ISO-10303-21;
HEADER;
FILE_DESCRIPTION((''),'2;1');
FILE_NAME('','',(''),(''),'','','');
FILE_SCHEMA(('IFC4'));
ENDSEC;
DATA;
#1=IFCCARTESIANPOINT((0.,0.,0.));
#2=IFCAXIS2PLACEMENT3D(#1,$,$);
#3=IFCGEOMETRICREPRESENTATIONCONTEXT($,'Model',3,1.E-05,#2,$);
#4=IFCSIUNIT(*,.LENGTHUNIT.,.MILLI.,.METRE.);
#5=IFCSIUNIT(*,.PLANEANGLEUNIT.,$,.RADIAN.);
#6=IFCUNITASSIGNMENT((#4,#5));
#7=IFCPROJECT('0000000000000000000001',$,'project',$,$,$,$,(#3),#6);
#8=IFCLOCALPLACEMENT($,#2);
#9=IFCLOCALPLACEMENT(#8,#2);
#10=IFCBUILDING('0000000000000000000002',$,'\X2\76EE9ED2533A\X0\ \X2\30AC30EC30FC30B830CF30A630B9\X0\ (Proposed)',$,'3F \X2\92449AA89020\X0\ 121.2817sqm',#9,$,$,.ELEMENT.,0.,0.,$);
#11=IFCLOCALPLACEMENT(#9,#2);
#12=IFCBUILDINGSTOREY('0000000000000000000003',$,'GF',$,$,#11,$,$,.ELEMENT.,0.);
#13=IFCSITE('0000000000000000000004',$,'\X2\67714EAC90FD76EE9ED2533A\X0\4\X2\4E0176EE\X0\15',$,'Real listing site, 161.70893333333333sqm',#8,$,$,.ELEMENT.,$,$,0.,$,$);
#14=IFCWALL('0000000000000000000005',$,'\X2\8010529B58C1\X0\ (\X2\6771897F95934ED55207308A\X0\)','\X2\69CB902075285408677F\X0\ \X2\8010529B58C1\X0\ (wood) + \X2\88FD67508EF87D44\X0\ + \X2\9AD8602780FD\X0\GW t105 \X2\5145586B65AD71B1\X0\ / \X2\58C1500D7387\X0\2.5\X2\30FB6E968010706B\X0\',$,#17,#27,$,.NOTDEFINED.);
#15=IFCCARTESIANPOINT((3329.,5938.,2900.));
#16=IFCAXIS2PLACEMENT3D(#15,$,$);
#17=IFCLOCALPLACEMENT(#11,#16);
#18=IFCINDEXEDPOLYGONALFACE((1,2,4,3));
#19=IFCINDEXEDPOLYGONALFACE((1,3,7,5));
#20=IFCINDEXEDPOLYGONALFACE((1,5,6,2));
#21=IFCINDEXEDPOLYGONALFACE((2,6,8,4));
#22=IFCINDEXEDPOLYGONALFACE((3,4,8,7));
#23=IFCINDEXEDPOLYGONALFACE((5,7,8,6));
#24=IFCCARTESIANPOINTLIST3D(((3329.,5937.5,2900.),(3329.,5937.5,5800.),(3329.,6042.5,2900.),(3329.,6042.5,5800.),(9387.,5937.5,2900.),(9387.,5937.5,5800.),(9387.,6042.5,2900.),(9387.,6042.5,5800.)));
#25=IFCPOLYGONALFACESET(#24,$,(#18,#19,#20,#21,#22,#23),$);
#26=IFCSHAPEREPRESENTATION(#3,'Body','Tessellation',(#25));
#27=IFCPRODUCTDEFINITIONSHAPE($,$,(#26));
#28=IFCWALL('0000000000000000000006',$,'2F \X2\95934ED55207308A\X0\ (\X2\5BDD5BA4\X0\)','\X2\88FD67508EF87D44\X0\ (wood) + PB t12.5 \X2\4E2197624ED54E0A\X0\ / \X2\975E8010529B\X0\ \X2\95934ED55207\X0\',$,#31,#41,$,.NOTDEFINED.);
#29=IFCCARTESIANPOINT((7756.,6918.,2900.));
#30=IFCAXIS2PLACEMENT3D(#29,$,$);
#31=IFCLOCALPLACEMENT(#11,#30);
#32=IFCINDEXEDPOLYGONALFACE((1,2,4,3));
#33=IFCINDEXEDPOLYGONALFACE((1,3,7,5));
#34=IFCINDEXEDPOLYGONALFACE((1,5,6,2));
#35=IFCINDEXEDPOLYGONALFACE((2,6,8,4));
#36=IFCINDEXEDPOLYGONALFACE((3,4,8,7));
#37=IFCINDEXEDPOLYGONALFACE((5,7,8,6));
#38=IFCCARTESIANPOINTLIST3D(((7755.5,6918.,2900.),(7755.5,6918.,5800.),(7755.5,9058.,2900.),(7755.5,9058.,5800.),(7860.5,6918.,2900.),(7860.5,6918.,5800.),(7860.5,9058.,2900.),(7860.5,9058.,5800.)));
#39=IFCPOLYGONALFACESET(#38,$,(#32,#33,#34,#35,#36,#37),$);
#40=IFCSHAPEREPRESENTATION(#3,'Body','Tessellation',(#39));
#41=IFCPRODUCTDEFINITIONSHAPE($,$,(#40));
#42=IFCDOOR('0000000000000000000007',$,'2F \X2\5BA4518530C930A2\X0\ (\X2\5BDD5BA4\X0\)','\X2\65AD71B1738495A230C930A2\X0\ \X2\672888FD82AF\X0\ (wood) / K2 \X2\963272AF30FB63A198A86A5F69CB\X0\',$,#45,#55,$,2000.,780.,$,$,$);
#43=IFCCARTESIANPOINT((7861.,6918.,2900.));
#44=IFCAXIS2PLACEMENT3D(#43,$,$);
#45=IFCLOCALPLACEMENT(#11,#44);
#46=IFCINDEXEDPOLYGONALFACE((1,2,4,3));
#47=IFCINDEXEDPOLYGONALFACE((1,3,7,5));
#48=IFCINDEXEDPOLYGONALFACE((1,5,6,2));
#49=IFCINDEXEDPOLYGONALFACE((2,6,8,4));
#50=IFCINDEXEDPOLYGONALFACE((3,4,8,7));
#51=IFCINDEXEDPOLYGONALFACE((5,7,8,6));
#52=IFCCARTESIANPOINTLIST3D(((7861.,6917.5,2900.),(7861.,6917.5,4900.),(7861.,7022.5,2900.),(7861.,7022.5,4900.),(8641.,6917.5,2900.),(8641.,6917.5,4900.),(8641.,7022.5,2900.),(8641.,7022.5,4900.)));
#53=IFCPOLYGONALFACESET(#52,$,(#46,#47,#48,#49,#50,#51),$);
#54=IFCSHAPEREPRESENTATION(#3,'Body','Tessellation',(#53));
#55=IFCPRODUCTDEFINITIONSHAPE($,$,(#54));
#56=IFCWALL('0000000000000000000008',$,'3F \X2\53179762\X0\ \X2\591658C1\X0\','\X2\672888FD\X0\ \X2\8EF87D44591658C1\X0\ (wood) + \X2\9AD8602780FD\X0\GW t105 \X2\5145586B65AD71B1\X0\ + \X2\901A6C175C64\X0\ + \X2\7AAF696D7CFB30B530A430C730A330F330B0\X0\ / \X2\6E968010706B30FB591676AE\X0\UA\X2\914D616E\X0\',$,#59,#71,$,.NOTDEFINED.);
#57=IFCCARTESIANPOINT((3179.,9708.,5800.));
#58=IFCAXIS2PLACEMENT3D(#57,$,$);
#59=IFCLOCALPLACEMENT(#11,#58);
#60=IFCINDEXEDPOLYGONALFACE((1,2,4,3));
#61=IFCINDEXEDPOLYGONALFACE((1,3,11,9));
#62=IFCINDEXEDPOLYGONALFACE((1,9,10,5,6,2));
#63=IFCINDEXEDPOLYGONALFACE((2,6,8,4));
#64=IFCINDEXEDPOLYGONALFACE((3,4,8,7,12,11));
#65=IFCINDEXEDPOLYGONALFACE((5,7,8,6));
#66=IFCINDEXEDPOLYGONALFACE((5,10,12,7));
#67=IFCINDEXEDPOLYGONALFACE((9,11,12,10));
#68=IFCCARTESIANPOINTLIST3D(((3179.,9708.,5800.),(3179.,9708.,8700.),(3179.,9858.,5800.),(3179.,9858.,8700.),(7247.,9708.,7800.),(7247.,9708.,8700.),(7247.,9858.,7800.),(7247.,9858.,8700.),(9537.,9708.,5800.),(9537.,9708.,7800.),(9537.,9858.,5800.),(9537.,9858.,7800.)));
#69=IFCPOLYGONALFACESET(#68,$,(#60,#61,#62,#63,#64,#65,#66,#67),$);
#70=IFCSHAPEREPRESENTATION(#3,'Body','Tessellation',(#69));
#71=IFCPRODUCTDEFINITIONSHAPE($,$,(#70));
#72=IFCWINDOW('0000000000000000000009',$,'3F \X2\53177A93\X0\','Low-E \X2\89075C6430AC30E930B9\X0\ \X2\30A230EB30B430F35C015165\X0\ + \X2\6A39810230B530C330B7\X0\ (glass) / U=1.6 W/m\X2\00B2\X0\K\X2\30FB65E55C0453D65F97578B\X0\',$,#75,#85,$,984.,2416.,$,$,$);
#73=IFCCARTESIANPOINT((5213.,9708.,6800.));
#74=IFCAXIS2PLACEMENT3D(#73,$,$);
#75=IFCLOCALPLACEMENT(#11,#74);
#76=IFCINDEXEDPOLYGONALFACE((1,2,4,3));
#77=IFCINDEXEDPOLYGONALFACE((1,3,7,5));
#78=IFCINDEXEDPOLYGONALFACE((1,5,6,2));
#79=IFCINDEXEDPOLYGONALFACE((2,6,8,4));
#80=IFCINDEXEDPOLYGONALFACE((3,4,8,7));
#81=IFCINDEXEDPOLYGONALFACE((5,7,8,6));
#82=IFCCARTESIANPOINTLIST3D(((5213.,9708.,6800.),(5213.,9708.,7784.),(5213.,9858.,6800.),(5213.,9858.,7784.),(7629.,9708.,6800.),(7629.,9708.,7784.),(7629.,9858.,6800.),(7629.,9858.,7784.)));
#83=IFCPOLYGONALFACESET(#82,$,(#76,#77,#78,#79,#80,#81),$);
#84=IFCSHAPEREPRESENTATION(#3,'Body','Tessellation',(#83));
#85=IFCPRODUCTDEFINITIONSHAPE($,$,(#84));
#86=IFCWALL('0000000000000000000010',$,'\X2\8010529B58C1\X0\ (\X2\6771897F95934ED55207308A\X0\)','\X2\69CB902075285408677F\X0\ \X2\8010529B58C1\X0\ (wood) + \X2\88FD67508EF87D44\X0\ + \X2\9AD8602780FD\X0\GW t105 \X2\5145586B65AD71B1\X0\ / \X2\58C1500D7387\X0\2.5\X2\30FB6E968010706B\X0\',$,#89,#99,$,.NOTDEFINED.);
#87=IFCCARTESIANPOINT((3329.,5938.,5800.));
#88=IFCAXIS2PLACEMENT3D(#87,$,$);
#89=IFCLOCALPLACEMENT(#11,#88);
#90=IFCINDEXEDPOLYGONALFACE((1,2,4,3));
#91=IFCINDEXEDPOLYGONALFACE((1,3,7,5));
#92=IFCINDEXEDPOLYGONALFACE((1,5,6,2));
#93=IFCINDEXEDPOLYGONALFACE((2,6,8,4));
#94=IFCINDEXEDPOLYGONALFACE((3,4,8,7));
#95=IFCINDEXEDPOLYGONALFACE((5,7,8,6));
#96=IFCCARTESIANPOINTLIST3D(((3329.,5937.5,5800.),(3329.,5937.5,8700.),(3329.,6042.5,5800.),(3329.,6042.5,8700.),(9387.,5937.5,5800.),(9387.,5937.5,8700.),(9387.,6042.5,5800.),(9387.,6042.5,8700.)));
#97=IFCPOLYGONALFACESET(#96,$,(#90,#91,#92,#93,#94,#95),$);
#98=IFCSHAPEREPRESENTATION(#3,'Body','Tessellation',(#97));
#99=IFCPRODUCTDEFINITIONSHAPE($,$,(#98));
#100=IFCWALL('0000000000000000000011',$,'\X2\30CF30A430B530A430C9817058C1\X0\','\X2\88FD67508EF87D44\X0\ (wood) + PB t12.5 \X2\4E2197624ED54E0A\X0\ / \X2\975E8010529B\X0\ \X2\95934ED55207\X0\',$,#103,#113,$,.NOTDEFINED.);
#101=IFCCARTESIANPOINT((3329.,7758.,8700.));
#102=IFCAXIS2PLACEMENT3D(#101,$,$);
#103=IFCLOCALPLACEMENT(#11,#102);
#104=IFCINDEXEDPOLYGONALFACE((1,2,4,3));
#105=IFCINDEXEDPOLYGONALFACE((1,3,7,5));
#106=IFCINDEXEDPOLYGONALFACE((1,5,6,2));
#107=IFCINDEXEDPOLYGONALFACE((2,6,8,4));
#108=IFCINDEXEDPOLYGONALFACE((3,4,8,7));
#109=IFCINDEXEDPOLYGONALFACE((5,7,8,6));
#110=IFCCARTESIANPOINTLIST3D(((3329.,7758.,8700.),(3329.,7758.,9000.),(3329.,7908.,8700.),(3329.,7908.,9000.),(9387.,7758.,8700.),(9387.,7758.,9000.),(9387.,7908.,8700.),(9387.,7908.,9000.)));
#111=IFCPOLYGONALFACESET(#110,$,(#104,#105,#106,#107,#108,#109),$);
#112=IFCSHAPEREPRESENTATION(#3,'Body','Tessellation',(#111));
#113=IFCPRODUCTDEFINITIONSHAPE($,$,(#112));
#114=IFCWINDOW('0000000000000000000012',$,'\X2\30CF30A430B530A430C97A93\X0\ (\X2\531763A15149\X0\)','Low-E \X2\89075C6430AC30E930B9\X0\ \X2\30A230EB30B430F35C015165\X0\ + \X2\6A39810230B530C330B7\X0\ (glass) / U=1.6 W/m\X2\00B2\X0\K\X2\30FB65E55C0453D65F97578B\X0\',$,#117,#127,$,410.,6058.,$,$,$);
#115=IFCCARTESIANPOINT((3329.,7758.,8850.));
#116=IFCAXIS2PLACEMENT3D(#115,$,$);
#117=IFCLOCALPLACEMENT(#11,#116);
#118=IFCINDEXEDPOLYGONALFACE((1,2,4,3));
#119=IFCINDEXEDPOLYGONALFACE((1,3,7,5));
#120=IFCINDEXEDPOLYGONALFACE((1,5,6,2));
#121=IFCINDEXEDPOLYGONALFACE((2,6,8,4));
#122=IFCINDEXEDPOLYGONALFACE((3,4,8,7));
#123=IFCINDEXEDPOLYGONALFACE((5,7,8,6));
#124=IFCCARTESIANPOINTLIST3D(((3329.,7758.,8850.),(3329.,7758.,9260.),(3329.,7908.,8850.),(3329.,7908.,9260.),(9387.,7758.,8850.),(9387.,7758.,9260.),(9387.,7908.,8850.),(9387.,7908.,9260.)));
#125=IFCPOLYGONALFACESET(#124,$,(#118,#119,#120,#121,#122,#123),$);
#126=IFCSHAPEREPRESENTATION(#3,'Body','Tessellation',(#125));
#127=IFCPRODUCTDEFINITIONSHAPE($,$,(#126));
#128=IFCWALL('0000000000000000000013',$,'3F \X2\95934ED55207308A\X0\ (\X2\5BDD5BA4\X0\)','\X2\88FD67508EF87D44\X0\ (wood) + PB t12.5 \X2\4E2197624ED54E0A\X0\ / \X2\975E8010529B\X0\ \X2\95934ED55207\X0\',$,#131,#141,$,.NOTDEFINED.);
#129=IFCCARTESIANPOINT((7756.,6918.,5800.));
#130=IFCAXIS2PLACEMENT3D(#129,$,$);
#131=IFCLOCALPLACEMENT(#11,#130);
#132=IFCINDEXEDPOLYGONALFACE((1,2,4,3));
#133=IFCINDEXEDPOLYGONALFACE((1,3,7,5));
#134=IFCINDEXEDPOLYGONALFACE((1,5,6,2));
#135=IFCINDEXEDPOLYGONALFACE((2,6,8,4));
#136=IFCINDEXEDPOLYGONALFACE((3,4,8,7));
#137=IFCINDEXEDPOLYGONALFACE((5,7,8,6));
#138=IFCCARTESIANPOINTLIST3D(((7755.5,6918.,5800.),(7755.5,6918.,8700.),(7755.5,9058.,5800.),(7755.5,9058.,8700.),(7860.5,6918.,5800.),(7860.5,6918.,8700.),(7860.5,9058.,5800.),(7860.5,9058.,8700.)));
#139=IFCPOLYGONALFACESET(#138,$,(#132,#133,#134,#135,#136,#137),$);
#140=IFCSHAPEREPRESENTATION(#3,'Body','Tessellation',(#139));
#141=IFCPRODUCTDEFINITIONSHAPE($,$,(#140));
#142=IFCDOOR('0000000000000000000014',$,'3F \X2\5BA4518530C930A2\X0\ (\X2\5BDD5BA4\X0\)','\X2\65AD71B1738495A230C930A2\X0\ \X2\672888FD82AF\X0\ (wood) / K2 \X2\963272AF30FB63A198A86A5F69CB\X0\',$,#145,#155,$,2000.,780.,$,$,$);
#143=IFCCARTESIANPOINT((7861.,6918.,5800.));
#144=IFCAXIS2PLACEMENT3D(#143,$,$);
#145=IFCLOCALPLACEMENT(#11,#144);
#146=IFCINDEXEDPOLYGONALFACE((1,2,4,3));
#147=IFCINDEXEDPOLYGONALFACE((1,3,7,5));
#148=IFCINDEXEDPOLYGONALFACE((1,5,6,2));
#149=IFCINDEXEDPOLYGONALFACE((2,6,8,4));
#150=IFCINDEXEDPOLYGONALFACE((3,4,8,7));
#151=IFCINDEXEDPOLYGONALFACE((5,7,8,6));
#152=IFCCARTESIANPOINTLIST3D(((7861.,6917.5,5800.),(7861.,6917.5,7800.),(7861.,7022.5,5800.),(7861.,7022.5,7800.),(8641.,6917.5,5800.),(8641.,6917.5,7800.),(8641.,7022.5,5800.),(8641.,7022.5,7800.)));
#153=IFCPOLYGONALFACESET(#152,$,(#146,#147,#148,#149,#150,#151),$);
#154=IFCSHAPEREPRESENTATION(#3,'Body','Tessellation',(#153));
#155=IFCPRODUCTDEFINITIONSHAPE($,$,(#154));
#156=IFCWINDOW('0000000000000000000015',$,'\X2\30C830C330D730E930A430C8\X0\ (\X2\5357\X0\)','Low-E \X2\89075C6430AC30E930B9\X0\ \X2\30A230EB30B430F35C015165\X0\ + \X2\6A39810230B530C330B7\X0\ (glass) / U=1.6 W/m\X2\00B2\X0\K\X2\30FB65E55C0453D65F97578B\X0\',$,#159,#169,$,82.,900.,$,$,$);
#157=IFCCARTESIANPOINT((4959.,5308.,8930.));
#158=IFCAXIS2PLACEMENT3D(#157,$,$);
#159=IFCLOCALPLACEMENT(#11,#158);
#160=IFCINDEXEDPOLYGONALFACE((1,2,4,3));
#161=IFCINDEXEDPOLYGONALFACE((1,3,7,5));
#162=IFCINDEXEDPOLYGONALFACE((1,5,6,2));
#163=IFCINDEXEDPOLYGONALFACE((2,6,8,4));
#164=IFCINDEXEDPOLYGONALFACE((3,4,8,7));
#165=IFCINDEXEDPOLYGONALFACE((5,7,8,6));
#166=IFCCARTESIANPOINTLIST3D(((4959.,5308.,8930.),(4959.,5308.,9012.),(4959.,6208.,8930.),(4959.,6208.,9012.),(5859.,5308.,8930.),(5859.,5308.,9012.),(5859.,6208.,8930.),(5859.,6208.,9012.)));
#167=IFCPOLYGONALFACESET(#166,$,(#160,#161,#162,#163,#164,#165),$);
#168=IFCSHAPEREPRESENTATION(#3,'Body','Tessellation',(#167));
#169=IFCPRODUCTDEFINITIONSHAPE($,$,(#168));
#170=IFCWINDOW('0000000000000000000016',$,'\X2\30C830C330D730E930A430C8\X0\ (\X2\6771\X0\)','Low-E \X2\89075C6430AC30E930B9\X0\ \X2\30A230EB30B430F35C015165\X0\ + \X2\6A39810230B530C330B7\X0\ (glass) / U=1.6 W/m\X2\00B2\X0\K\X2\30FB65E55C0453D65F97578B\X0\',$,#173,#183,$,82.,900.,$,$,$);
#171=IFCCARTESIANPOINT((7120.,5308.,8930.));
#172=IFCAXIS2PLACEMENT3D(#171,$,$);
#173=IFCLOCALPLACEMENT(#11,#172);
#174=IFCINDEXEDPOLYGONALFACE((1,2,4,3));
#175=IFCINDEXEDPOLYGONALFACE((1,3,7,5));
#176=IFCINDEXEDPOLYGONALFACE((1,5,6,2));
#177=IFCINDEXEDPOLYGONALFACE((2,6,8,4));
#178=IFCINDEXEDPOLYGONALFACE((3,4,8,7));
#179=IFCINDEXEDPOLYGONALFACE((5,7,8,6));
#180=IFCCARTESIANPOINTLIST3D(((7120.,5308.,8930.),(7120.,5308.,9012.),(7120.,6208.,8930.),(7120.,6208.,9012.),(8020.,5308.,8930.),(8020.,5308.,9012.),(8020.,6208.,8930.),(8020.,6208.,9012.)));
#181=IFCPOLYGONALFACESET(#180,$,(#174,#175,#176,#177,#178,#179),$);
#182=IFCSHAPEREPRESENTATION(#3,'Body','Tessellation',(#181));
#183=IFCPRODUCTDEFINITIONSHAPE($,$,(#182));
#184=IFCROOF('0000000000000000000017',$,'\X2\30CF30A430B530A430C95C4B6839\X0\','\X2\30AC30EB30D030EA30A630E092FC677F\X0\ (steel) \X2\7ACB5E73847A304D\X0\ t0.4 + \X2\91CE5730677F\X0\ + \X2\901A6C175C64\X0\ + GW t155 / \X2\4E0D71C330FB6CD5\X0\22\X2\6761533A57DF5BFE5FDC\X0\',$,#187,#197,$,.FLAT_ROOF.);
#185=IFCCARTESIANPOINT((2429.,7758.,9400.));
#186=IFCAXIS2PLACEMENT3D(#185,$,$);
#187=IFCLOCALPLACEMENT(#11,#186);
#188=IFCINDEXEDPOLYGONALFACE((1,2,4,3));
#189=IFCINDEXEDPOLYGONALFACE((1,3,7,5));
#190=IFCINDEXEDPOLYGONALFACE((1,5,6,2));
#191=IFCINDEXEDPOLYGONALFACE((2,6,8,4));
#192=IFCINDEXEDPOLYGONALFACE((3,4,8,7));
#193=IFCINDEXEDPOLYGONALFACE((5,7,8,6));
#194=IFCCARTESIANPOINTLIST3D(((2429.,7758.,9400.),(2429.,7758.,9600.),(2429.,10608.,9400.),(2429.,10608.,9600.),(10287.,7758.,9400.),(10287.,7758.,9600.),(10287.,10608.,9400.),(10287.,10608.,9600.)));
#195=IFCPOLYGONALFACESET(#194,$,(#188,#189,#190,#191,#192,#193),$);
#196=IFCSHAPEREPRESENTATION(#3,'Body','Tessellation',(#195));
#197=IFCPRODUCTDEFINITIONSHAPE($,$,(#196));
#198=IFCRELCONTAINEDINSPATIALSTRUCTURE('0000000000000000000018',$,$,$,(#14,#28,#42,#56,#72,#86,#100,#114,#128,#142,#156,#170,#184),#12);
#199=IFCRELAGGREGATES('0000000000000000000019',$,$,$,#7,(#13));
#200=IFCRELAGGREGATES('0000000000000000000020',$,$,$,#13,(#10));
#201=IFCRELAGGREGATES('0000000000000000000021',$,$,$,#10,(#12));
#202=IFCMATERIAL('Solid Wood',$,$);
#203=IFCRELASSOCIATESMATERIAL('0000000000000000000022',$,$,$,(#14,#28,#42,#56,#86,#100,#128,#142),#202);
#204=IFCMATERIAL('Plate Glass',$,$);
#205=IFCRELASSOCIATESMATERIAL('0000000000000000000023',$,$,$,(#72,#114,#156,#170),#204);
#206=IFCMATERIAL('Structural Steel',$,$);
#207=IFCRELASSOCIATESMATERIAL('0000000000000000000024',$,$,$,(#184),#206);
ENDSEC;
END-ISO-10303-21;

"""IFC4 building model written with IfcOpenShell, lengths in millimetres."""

from ifc_helpers import new_model, si_unit, frame, frame_2d, origin, place, context, project, spatial, rectangle, extrude, material, element, fill, save


model = new_model("IFC4")

# Units and contexts
model_context = context("Model", 3, precision=1e-05, world=origin())
ifc_project = project(units=[si_unit("LENGTHUNIT", "METRE", prefix="MILLI"), si_unit("PLANEANGLEUNIT", "RADIAN")], contexts=[model_context])

# Site, building, storey
site_placement = place(None, origin())
site = spatial("IfcSite", under=ifc_project, at=site_placement, Name="東京都目黒区4丁目15", ObjectType="Real listing site, 161.70893333333333sqm", CompositionType="ELEMENT", RefElevation=0.0)
building_placement = place(site_placement, origin())
building = spatial("IfcBuilding", under=site, at=building_placement, Name="目黒区 ガレージハウス (Proposed)", ObjectType="3F 鉄骨造 121.2817sqm", CompositionType="ELEMENT", ElevationOfRefHeight=0.0, ElevationOfTerrain=0.0)
storey_placement = place(building_placement, origin())
storey = spatial("IfcBuildingStorey", under=building, at=storey_placement, Name="GF", CompositionType="ELEMENT", Elevation=0.0)

# Walls
ifc_material_1 = material(Name="Solid Wood")
wall_1_placement = place(storey_placement, frame((3329.0, 5938.0, 2900.0)))
element("IfcWall", 1, at=wall_1_placement, inside=storey, material=ifc_material_1, Name="耐力壁 (東西間仕切り)", Description="構造用合板 耐力壁 (wood) + 製材軸組 + 高性能GW t105 充填断熱 / 壁倍率2.5・準耐火", PredefinedType="NOTDEFINED", context=model_context, shape_type="SweptSolid", body=[
    extrude(rectangle(XDim=6058.0, YDim=105.0, at=frame_2d((3029.0, 52.0))), frame((3329.0, 5938.0, 2900.0)), (0.0, 0.0, 1.0), 2900.0),
])
wall_2_placement = place(storey_placement, frame((7756.0, 6918.0, 2900.0)))
element("IfcWall", 2, at=wall_2_placement, inside=storey, material=ifc_material_1, Name="2F 間仕切り (寝室)", Description="製材軸組 (wood) + PB t12.5 両面仕上 / 非耐力 間仕切", PredefinedType="NOTDEFINED", context=model_context, shape_type="SweptSolid", body=[
    extrude(rectangle(XDim=105.0, YDim=2140.0, at=frame_2d((52.0, 1070.0))), frame((7756.0, 6918.0, 2900.0)), (0.0, 0.0, 1.0), 2900.0),
])

# Door
door_1_placement = place(storey_placement, frame((7861.0, 6918.0, 2900.0)))
element("IfcDoor", 3, at=door_1_placement, inside=storey, material=ifc_material_1, Name="2F 室内ドア (寝室)", Description="断熱玄関ドア 木製芯 (wood) / K2 防犯・採風機構", OverallHeight=2000.0, OverallWidth=780.0, context=model_context, shape_type="SweptSolid", body=[
    extrude(rectangle(XDim=780.0, YDim=105.0, at=frame_2d((390.0, 52.0))), frame((7861.0, 6918.0, 2900.0)), (0.0, 0.0, 1.0), 2000.0),
])

# Wall, opening, window
wall_3_placement = place(storey_placement, frame((3179.0, 9708.0, 5800.0)))
wall_3 = element("IfcWall", 4, at=wall_3_placement, inside=storey, material=ifc_material_1, Name="3F 北面 外壁", Description="木製 軸組外壁 (wood) + 高性能GW t105 充填断熱 + 通気層 + 窯業系サイディング / 準耐火・外皮UA配慮", PredefinedType="NOTDEFINED", context=model_context, shape_type="SweptSolid", body=[
    extrude(rectangle(XDim=6358.0, YDim=150.0, at=frame_2d((3179.0, 75.0))), frame((3179.0, 9708.0, 5800.0)), (0.0, 0.0, 1.0), 2900.0),
])
opening_1_placement = place(storey_placement, frame((5213.0, 9708.0, 6800.0)))
opening_1 = element("IfcOpeningElement", 5, at=opening_1_placement, cuts=wall_3, PredefinedType="NOTDEFINED", context=model_context, shape_type="SweptSolid", body=[
    extrude(rectangle(XDim=2416.0, YDim=150.0, at=frame_2d((1208.0, 75.0))), frame((5213.0, 9708.0, 6800.0)), (0.0, 0.0, 1.0), 984.0),
])
ifc_material_2 = material(Name="Plate Glass")
window_1_placement = place(storey_placement, frame((5213.0, 9708.0, 6800.0)))
window_1 = element("IfcWindow", 6, at=window_1_placement, inside=storey, material=ifc_material_2, Name="3F 北窓", Description="Low-E 複層ガラス アルゴン封入 + 樹脂サッシ (glass) / U=1.6 W/m²K・日射取得型", OverallHeight=984.0, OverallWidth=2416.0, context=model_context, shape_type="SweptSolid", body=[
    extrude(rectangle(XDim=2416.0, YDim=150.0, at=frame_2d((1208.0, 75.0))), frame((5213.0, 9708.0, 6800.0)), (0.0, 0.0, 1.0), 984.0),
])
fill(opening_1, window_1)

# Wall
wall_4_placement = place(storey_placement, frame((3329.0, 5938.0, 5800.0)))
element("IfcWall", 7, at=wall_4_placement, inside=storey, material=ifc_material_1, Name="耐力壁 (東西間仕切り)", Description="構造用合板 耐力壁 (wood) + 製材軸組 + 高性能GW t105 充填断熱 / 壁倍率2.5・準耐火", PredefinedType="NOTDEFINED", context=model_context, shape_type="SweptSolid", body=[
    extrude(rectangle(XDim=6058.0, YDim=105.0, at=frame_2d((3029.0, 52.0))), frame((3329.0, 5938.0, 5800.0)), (0.0, 0.0, 1.0), 2900.0),
])

# Wall, opening, window
wall_5_placement = place(storey_placement, frame((3329.0, 7758.0, 8700.0)))
wall_5 = element("IfcWall", 8, at=wall_5_placement, inside=storey, material=ifc_material_1, Name="ハイサイド腰壁", Description="製材軸組 (wood) + PB t12.5 両面仕上 / 非耐力 間仕切", PredefinedType="NOTDEFINED", context=model_context, shape_type="SweptSolid", body=[
    extrude(rectangle(XDim=6058.0, YDim=150.0, at=frame_2d((3029.0, 75.0))), frame((3329.0, 7758.0, 8700.0)), (0.0, 0.0, 1.0), 700.0),
])
opening_2_placement = place(storey_placement, frame((3329.0, 7758.0, 8850.0)))
opening_2 = element("IfcOpeningElement", 9, at=opening_2_placement, cuts=wall_5, PredefinedType="NOTDEFINED", context=model_context, shape_type="SweptSolid", body=[
    extrude(rectangle(XDim=6058.0, YDim=150.0, at=frame_2d((3029.0, 75.0))), frame((3329.0, 7758.0, 8850.0)), (0.0, 0.0, 1.0), 410.0),
])
window_2_placement = place(storey_placement, frame((3329.0, 7758.0, 8850.0)))
window_2 = element("IfcWindow", 10, at=window_2_placement, inside=storey, material=ifc_material_2, Name="ハイサイド窓 (北採光)", Description="Low-E 複層ガラス アルゴン封入 + 樹脂サッシ (glass) / U=1.6 W/m²K・日射取得型", OverallHeight=410.0, OverallWidth=6058.0, context=model_context, shape_type="SweptSolid", body=[
    extrude(rectangle(XDim=6058.0, YDim=150.0, at=frame_2d((3029.0, 75.0))), frame((3329.0, 7758.0, 8850.0)), (0.0, 0.0, 1.0), 410.0),
])
fill(opening_2, window_2)

# Wall
wall_6_placement = place(storey_placement, frame((7756.0, 6918.0, 5800.0)))
element("IfcWall", 11, at=wall_6_placement, inside=storey, material=ifc_material_1, Name="3F 間仕切り (寝室)", Description="製材軸組 (wood) + PB t12.5 両面仕上 / 非耐力 間仕切", PredefinedType="NOTDEFINED", context=model_context, shape_type="SweptSolid", body=[
    extrude(rectangle(XDim=105.0, YDim=2140.0, at=frame_2d((52.0, 1070.0))), frame((7756.0, 6918.0, 5800.0)), (0.0, 0.0, 1.0), 2900.0),
])

# Door
door_2_placement = place(storey_placement, frame((7861.0, 6918.0, 5800.0)))
element("IfcDoor", 12, at=door_2_placement, inside=storey, material=ifc_material_1, Name="3F 室内ドア (寝室)", Description="断熱玄関ドア 木製芯 (wood) / K2 防犯・採風機構", OverallHeight=2000.0, OverallWidth=780.0, context=model_context, shape_type="SweptSolid", body=[
    extrude(rectangle(XDim=780.0, YDim=105.0, at=frame_2d((390.0, 52.0))), frame((7861.0, 6918.0, 5800.0)), (0.0, 0.0, 1.0), 2000.0),
])

# Windows
window_3_placement = place(storey_placement, frame((4959.0, 5308.0, 8930.0)))
element("IfcWindow", 13, at=window_3_placement, inside=storey, material=ifc_material_2, Name="トップライト (南)", Description="Low-E 複層ガラス アルゴン封入 + 樹脂サッシ (glass) / U=1.6 W/m²K・日射取得型", OverallHeight=82.0, OverallWidth=900.0, context=model_context, shape_type="SweptSolid", body=[
    extrude(rectangle(XDim=900.0, YDim=900.0, at=frame_2d((450.0, 450.0))), frame((4959.0, 5308.0, 8930.0)), (0.0, 0.0, 1.0), 82.0),
])
window_4_placement = place(storey_placement, frame((7120.0, 5308.0, 8930.0)))
element("IfcWindow", 14, at=window_4_placement, inside=storey, material=ifc_material_2, Name="トップライト (東)", Description="Low-E 複層ガラス アルゴン封入 + 樹脂サッシ (glass) / U=1.6 W/m²K・日射取得型", OverallHeight=82.0, OverallWidth=900.0, context=model_context, shape_type="SweptSolid", body=[
    extrude(rectangle(XDim=900.0, YDim=900.0, at=frame_2d((450.0, 450.0))), frame((7120.0, 5308.0, 8930.0)), (0.0, 0.0, 1.0), 82.0),
])

# Roof
ifc_material_3 = material(Name="Structural Steel")
roof_placement = place(storey_placement, frame((2429.0, 7758.0, 9400.0)))
element("IfcRoof", 15, at=roof_placement, inside=storey, material=ifc_material_3, Name="ハイサイド屋根", Description="ガルバリウム鋼板 (steel) 立平葺き t0.4 + 野地板 + 通気層 + GW t155 / 不燃・法22条区域対応", PredefinedType="FLAT_ROOF", context=model_context, shape_type="SweptSolid", body=[
    extrude(rectangle(XDim=7858.0, YDim=2850.0, at=frame_2d((3929.0, 1425.0))), frame((2429.0, 7758.0, 9400.0)), (0.0, 0.0, 1.0), 200.0),
])

save(model, "model.ifc")
